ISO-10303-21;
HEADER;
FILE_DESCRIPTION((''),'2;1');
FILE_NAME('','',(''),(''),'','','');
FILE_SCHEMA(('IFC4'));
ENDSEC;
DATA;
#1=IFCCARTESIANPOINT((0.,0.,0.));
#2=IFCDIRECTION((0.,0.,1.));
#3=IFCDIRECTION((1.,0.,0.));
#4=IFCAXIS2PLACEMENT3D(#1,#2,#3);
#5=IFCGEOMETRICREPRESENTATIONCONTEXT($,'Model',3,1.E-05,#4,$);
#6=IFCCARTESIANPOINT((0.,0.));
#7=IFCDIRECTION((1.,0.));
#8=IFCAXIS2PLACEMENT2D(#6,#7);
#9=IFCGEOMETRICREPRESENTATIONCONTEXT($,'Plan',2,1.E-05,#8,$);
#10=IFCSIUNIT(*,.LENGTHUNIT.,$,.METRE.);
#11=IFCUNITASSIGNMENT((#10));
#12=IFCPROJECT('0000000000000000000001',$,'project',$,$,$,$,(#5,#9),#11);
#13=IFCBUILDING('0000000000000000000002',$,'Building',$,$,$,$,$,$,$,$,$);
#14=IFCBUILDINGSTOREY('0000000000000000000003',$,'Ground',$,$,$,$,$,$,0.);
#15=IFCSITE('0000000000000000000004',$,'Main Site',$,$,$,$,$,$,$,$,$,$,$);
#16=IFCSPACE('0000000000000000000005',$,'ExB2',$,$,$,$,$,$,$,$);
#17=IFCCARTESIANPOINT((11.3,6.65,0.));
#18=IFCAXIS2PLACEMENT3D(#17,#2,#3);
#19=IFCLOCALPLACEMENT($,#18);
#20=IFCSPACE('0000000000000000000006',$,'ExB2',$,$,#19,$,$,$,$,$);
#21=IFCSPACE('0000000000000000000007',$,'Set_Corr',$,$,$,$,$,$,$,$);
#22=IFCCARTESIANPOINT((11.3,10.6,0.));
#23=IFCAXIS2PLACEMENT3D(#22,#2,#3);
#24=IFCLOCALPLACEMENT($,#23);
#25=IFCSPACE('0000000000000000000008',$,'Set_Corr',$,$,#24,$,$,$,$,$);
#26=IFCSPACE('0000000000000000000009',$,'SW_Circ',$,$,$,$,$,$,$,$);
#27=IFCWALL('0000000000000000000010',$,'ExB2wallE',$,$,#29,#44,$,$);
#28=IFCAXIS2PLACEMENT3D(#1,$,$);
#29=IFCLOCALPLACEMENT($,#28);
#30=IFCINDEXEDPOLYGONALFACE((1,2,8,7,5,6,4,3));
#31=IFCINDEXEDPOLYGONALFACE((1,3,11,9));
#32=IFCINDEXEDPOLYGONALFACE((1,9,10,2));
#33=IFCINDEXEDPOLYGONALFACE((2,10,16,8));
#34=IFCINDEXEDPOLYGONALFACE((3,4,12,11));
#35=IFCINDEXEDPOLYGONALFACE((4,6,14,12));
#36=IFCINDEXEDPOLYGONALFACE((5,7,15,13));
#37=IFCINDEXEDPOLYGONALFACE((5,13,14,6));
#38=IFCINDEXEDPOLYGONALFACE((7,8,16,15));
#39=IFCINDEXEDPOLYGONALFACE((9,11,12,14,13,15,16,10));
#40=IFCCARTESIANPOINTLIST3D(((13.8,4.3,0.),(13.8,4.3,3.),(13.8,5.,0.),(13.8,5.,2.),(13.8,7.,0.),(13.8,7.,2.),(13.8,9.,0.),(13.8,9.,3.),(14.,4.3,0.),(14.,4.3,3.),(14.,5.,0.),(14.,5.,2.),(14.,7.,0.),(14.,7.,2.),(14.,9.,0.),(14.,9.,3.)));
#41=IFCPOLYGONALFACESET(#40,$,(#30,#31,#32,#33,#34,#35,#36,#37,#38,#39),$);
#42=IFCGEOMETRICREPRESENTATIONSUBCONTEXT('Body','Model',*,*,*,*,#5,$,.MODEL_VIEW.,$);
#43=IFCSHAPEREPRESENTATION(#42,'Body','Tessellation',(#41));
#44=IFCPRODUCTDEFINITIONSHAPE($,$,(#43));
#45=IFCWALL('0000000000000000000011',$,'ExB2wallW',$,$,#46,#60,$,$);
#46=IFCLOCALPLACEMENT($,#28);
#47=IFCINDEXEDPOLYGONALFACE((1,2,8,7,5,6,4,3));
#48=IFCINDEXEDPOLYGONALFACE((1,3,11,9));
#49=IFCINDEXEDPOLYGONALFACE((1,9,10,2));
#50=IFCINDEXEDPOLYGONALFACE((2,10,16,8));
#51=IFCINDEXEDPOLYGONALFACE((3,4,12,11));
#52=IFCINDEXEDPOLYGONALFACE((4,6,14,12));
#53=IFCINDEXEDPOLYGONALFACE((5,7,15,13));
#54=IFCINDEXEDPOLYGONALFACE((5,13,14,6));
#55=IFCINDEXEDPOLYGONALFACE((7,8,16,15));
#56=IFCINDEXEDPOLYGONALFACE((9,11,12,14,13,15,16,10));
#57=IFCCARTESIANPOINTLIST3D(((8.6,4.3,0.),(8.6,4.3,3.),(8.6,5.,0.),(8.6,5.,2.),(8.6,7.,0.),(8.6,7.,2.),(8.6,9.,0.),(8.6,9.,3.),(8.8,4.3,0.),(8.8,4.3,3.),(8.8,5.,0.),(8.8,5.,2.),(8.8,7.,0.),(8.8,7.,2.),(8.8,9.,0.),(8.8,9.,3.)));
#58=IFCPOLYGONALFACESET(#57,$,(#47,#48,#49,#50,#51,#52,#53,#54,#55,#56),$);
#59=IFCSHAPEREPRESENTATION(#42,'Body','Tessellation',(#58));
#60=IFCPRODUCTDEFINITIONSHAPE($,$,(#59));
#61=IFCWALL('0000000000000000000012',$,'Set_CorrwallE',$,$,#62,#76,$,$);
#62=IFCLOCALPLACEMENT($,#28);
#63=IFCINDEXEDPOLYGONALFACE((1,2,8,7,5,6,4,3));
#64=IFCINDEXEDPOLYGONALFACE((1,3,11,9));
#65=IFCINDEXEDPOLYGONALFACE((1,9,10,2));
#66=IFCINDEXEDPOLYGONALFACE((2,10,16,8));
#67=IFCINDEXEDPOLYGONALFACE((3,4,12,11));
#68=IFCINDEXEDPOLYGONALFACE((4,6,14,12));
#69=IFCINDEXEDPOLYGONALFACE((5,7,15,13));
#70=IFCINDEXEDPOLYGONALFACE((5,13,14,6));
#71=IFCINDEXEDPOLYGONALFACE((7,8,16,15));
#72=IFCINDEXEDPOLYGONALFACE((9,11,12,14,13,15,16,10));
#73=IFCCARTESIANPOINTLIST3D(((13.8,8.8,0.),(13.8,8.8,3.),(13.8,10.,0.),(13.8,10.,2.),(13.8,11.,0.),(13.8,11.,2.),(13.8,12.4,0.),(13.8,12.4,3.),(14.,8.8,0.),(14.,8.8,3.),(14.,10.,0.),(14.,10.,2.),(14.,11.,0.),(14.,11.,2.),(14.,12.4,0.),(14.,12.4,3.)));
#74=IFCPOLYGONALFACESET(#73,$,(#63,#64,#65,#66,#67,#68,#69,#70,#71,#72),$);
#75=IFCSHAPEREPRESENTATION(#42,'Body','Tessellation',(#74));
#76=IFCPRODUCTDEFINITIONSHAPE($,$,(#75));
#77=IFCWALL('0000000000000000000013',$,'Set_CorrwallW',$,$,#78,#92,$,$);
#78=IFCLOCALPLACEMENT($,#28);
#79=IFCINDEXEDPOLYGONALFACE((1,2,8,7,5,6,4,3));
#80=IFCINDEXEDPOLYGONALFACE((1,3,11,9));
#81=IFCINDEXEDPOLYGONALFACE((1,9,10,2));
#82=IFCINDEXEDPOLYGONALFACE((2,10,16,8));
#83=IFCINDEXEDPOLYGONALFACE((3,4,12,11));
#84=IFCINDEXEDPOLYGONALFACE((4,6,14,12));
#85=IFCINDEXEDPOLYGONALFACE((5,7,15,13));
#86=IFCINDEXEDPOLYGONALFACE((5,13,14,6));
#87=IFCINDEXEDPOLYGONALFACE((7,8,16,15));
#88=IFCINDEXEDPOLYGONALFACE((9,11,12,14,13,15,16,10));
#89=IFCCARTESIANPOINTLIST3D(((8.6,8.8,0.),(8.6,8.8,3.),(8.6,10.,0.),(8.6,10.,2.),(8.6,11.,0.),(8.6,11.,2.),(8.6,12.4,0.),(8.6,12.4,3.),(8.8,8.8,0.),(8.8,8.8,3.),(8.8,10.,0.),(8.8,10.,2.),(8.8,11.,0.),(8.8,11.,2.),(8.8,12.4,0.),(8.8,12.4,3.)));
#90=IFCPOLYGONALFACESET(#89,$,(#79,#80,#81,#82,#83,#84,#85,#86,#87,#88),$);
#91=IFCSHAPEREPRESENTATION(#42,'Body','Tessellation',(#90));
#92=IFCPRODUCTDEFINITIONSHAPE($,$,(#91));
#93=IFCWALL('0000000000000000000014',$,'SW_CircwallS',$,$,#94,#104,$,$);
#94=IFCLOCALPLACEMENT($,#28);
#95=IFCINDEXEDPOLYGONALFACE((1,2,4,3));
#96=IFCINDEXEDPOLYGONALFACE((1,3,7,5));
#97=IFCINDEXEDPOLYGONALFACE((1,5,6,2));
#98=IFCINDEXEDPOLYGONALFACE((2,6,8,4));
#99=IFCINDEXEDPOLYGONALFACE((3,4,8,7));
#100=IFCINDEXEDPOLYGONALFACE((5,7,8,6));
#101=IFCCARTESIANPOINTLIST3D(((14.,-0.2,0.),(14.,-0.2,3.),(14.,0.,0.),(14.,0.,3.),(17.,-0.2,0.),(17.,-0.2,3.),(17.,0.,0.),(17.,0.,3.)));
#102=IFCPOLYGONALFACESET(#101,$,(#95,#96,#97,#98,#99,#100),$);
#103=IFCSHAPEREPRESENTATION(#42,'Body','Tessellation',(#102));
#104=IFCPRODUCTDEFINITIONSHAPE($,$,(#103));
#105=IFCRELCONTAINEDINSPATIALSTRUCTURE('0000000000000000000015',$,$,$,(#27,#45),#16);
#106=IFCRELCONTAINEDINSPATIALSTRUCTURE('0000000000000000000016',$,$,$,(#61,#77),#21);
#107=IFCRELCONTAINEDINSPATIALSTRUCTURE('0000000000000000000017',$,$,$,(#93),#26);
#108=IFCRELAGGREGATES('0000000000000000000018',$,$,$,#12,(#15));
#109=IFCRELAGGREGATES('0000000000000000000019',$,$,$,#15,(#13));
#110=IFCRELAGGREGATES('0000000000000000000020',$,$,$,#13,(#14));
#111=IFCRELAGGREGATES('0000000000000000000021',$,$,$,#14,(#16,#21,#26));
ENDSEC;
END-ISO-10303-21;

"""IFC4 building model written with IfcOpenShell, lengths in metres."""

from ifc_helpers import new_model, si_unit, frame, origin_with_axes, origin_2d_with_axis, place, context, subcontext, project, spatial, indexed_curve, outline, extrude, element, save


model = new_model("IFC4")

# Units and contexts
model_context = context("Model", 3, precision=1e-05, world=origin_with_axes())
plan_context = context("Plan", 2, precision=1e-05, world=origin_2d_with_axis())
body_context = subcontext(model_context, "Body", "Model", "MODEL_VIEW")
ifc_project = project(units=[si_unit("LENGTHUNIT", "METRE")], contexts=[model_context, plan_context])

# Site, building, storey
site = spatial("IfcSite", under=ifc_project, Name="Main Site")
building = spatial("IfcBuilding", under=site, Name="Building")
storey = spatial("IfcBuildingStorey", under=building, Name="Ground", Elevation=0.0)

# Shared definitions
space_1 = spatial("IfcSpace", under=storey, Name="ExB2")

# Wall
wall_1_placement = place(None, frame((14.0, 4.3, 0.0), z_axis=(0.0, 0.0, 1.0), x_axis=(0.0, 1.0, 0.0)))
wall_1 = element("IfcWall", 1, at=wall_1_placement, inside=space_1, Name="ExB2wallE", context=body_context, shape_type="SweptSolid", body=[
    extrude(outline(indexed_curve([(0.0, 0.0), (0.0, 0.2), (4.7, 0.2), (4.7, 0.0), (0.0, 0.0)], self_intersect=False)), origin_with_axes(), (0.0, 0.0, 1.0), 3.0),
])

# Shared definitions
space_2_placement = place(None, frame((11.3, 6.65, 0.0), z_axis=(0.0, 0.0, 1.0), x_axis=(1.0, 0.0, 0.0)))
space_2 = spatial("IfcSpace", at=space_2_placement, Name="ExB2")

# Opening
opening_1_placement = place(wall_1_placement, frame((0.7, 0.0, 0.0), z_axis=(0.0, 0.0, 1.0), x_axis=(1.0, 0.0, 0.0)))
element("IfcOpeningElement", 2, at=opening_1_placement, inside=space_2, cuts=wall_1, context=body_context, shape_type="SweptSolid", body=[
    extrude(outline(indexed_curve([(0.0, 0.0), (0.0, 0.4), (2.0, 0.4), (2.0, 0.0), (0.0, 0.0)], self_intersect=False)), origin_with_axes(), (0.0, 0.0, 1.0), 2.0),
])

# Wall, opening
wall_2_placement = place(None, frame((8.8, 4.3, 0.0), z_axis=(0.0, 0.0, 1.0), x_axis=(0.0, 1.0, 0.0)))
wall_2 = element("IfcWall", 3, at=wall_2_placement, inside=space_1, Name="ExB2wallW", context=body_context, shape_type="SweptSolid", body=[
    extrude(outline(indexed_curve([(0.0, 0.0), (0.0, 0.2), (4.7, 0.2), (4.7, 0.0), (0.0, 0.0)], self_intersect=False)), origin_with_axes(), (0.0, 0.0, 1.0), 3.0),
])
opening_2_placement = place(wall_2_placement, frame((0.7, 0.0, 0.0), z_axis=(0.0, 0.0, 1.0), x_axis=(1.0, 0.0, 0.0)))
element("IfcOpeningElement", 4, at=opening_2_placement, inside=space_2, cuts=wall_2, context=body_context, shape_type="SweptSolid", body=[
    extrude(outline(indexed_curve([(0.0, 0.0), (0.0, 0.4), (2.0, 0.4), (2.0, 0.0), (0.0, 0.0)], self_intersect=False)), origin_with_axes(), (0.0, 0.0, 1.0), 2.0),
])

# Shared definitions
space_3 = spatial("IfcSpace", under=storey, Name="Set_Corr")

# Wall
wall_3_placement = place(None, frame((14.0, 8.8, 0.0), z_axis=(0.0, 0.0, 1.0), x_axis=(0.0, 1.0, 0.0)))
wall_3 = element("IfcWall", 5, at=wall_3_placement, inside=space_3, Name="Set_CorrwallE", context=body_context, shape_type="SweptSolid", body=[
    extrude(outline(indexed_curve([(0.0, 0.0), (0.0, 0.2), (3.6, 0.2), (3.6, 0.0), (0.0, 0.0)], self_intersect=False)), origin_with_axes(), (0.0, 0.0, 1.0), 3.0),
])

# Shared definitions
space_4_placement = place(None, frame((11.3, 10.6, 0.0), z_axis=(0.0, 0.0, 1.0), x_axis=(1.0, 0.0, 0.0)))
space_4 = spatial("IfcSpace", at=space_4_placement, Name="Set_Corr")

# Opening
opening_3_placement = place(wall_3_placement, frame((1.2, 0.0, 0.0), z_axis=(0.0, 0.0, 1.0), x_axis=(1.0, 0.0, 0.0)))
element("IfcOpeningElement", 6, at=opening_3_placement, inside=space_4, cuts=wall_3, context=body_context, shape_type="SweptSolid", body=[
    extrude(outline(indexed_curve([(0.0, 0.0), (0.0, 0.4), (1.0, 0.4), (1.0, 0.0), (0.0, 0.0)], self_intersect=False)), origin_with_axes(), (0.0, 0.0, 1.0), 2.0),
])

# Wall, opening
wall_4_placement = place(None, frame((8.8, 8.8, 0.0), z_axis=(0.0, 0.0, 1.0), x_axis=(0.0, 1.0, 0.0)))
wall_4 = element("IfcWall", 7, at=wall_4_placement, inside=space_3, Name="Set_CorrwallW", context=body_context, shape_type="SweptSolid", body=[
    extrude(outline(indexed_curve([(0.0, 0.0), (0.0, 0.2), (3.6, 0.2), (3.6, 0.0), (0.0, 0.0)], self_intersect=False)), origin_with_axes(), (0.0, 0.0, 1.0), 3.0),
])
opening_4_placement = place(wall_4_placement, frame((1.2, 0.0, 0.0), z_axis=(0.0, 0.0, 1.0), x_axis=(1.0, 0.0, 0.0)))
element("IfcOpeningElement", 8, at=opening_4_placement, inside=space_4, cuts=wall_4, context=body_context, shape_type="SweptSolid", body=[
    extrude(outline(indexed_curve([(0.0, 0.0), (0.0, 0.4), (1.0, 0.4), (1.0, 0.0), (0.0, 0.0)], self_intersect=False)), origin_with_axes(), (0.0, 0.0, 1.0), 2.0),
])

# Shared definitions
space_5 = spatial("IfcSpace", under=storey, Name="SW_Circ")

# Wall
wall_5_placement = place(None, frame((14.0, -0.2, 0.0), z_axis=(0.0, 0.0, 1.0), x_axis=(1.0, 0.0, 0.0)))
element("IfcWall", 9, at=wall_5_placement, inside=space_5, Name="SW_CircwallS", context=body_context, shape_type="SweptSolid", body=[
    extrude(outline(indexed_curve([(0.0, 0.0), (0.0, 0.2), (3.0, 0.2), (3.0, 0.0), (0.0, 0.0)], self_intersect=False)), origin_with_axes(), (0.0, 0.0, 1.0), 3.0),
])

save(model, "model.ifc")
